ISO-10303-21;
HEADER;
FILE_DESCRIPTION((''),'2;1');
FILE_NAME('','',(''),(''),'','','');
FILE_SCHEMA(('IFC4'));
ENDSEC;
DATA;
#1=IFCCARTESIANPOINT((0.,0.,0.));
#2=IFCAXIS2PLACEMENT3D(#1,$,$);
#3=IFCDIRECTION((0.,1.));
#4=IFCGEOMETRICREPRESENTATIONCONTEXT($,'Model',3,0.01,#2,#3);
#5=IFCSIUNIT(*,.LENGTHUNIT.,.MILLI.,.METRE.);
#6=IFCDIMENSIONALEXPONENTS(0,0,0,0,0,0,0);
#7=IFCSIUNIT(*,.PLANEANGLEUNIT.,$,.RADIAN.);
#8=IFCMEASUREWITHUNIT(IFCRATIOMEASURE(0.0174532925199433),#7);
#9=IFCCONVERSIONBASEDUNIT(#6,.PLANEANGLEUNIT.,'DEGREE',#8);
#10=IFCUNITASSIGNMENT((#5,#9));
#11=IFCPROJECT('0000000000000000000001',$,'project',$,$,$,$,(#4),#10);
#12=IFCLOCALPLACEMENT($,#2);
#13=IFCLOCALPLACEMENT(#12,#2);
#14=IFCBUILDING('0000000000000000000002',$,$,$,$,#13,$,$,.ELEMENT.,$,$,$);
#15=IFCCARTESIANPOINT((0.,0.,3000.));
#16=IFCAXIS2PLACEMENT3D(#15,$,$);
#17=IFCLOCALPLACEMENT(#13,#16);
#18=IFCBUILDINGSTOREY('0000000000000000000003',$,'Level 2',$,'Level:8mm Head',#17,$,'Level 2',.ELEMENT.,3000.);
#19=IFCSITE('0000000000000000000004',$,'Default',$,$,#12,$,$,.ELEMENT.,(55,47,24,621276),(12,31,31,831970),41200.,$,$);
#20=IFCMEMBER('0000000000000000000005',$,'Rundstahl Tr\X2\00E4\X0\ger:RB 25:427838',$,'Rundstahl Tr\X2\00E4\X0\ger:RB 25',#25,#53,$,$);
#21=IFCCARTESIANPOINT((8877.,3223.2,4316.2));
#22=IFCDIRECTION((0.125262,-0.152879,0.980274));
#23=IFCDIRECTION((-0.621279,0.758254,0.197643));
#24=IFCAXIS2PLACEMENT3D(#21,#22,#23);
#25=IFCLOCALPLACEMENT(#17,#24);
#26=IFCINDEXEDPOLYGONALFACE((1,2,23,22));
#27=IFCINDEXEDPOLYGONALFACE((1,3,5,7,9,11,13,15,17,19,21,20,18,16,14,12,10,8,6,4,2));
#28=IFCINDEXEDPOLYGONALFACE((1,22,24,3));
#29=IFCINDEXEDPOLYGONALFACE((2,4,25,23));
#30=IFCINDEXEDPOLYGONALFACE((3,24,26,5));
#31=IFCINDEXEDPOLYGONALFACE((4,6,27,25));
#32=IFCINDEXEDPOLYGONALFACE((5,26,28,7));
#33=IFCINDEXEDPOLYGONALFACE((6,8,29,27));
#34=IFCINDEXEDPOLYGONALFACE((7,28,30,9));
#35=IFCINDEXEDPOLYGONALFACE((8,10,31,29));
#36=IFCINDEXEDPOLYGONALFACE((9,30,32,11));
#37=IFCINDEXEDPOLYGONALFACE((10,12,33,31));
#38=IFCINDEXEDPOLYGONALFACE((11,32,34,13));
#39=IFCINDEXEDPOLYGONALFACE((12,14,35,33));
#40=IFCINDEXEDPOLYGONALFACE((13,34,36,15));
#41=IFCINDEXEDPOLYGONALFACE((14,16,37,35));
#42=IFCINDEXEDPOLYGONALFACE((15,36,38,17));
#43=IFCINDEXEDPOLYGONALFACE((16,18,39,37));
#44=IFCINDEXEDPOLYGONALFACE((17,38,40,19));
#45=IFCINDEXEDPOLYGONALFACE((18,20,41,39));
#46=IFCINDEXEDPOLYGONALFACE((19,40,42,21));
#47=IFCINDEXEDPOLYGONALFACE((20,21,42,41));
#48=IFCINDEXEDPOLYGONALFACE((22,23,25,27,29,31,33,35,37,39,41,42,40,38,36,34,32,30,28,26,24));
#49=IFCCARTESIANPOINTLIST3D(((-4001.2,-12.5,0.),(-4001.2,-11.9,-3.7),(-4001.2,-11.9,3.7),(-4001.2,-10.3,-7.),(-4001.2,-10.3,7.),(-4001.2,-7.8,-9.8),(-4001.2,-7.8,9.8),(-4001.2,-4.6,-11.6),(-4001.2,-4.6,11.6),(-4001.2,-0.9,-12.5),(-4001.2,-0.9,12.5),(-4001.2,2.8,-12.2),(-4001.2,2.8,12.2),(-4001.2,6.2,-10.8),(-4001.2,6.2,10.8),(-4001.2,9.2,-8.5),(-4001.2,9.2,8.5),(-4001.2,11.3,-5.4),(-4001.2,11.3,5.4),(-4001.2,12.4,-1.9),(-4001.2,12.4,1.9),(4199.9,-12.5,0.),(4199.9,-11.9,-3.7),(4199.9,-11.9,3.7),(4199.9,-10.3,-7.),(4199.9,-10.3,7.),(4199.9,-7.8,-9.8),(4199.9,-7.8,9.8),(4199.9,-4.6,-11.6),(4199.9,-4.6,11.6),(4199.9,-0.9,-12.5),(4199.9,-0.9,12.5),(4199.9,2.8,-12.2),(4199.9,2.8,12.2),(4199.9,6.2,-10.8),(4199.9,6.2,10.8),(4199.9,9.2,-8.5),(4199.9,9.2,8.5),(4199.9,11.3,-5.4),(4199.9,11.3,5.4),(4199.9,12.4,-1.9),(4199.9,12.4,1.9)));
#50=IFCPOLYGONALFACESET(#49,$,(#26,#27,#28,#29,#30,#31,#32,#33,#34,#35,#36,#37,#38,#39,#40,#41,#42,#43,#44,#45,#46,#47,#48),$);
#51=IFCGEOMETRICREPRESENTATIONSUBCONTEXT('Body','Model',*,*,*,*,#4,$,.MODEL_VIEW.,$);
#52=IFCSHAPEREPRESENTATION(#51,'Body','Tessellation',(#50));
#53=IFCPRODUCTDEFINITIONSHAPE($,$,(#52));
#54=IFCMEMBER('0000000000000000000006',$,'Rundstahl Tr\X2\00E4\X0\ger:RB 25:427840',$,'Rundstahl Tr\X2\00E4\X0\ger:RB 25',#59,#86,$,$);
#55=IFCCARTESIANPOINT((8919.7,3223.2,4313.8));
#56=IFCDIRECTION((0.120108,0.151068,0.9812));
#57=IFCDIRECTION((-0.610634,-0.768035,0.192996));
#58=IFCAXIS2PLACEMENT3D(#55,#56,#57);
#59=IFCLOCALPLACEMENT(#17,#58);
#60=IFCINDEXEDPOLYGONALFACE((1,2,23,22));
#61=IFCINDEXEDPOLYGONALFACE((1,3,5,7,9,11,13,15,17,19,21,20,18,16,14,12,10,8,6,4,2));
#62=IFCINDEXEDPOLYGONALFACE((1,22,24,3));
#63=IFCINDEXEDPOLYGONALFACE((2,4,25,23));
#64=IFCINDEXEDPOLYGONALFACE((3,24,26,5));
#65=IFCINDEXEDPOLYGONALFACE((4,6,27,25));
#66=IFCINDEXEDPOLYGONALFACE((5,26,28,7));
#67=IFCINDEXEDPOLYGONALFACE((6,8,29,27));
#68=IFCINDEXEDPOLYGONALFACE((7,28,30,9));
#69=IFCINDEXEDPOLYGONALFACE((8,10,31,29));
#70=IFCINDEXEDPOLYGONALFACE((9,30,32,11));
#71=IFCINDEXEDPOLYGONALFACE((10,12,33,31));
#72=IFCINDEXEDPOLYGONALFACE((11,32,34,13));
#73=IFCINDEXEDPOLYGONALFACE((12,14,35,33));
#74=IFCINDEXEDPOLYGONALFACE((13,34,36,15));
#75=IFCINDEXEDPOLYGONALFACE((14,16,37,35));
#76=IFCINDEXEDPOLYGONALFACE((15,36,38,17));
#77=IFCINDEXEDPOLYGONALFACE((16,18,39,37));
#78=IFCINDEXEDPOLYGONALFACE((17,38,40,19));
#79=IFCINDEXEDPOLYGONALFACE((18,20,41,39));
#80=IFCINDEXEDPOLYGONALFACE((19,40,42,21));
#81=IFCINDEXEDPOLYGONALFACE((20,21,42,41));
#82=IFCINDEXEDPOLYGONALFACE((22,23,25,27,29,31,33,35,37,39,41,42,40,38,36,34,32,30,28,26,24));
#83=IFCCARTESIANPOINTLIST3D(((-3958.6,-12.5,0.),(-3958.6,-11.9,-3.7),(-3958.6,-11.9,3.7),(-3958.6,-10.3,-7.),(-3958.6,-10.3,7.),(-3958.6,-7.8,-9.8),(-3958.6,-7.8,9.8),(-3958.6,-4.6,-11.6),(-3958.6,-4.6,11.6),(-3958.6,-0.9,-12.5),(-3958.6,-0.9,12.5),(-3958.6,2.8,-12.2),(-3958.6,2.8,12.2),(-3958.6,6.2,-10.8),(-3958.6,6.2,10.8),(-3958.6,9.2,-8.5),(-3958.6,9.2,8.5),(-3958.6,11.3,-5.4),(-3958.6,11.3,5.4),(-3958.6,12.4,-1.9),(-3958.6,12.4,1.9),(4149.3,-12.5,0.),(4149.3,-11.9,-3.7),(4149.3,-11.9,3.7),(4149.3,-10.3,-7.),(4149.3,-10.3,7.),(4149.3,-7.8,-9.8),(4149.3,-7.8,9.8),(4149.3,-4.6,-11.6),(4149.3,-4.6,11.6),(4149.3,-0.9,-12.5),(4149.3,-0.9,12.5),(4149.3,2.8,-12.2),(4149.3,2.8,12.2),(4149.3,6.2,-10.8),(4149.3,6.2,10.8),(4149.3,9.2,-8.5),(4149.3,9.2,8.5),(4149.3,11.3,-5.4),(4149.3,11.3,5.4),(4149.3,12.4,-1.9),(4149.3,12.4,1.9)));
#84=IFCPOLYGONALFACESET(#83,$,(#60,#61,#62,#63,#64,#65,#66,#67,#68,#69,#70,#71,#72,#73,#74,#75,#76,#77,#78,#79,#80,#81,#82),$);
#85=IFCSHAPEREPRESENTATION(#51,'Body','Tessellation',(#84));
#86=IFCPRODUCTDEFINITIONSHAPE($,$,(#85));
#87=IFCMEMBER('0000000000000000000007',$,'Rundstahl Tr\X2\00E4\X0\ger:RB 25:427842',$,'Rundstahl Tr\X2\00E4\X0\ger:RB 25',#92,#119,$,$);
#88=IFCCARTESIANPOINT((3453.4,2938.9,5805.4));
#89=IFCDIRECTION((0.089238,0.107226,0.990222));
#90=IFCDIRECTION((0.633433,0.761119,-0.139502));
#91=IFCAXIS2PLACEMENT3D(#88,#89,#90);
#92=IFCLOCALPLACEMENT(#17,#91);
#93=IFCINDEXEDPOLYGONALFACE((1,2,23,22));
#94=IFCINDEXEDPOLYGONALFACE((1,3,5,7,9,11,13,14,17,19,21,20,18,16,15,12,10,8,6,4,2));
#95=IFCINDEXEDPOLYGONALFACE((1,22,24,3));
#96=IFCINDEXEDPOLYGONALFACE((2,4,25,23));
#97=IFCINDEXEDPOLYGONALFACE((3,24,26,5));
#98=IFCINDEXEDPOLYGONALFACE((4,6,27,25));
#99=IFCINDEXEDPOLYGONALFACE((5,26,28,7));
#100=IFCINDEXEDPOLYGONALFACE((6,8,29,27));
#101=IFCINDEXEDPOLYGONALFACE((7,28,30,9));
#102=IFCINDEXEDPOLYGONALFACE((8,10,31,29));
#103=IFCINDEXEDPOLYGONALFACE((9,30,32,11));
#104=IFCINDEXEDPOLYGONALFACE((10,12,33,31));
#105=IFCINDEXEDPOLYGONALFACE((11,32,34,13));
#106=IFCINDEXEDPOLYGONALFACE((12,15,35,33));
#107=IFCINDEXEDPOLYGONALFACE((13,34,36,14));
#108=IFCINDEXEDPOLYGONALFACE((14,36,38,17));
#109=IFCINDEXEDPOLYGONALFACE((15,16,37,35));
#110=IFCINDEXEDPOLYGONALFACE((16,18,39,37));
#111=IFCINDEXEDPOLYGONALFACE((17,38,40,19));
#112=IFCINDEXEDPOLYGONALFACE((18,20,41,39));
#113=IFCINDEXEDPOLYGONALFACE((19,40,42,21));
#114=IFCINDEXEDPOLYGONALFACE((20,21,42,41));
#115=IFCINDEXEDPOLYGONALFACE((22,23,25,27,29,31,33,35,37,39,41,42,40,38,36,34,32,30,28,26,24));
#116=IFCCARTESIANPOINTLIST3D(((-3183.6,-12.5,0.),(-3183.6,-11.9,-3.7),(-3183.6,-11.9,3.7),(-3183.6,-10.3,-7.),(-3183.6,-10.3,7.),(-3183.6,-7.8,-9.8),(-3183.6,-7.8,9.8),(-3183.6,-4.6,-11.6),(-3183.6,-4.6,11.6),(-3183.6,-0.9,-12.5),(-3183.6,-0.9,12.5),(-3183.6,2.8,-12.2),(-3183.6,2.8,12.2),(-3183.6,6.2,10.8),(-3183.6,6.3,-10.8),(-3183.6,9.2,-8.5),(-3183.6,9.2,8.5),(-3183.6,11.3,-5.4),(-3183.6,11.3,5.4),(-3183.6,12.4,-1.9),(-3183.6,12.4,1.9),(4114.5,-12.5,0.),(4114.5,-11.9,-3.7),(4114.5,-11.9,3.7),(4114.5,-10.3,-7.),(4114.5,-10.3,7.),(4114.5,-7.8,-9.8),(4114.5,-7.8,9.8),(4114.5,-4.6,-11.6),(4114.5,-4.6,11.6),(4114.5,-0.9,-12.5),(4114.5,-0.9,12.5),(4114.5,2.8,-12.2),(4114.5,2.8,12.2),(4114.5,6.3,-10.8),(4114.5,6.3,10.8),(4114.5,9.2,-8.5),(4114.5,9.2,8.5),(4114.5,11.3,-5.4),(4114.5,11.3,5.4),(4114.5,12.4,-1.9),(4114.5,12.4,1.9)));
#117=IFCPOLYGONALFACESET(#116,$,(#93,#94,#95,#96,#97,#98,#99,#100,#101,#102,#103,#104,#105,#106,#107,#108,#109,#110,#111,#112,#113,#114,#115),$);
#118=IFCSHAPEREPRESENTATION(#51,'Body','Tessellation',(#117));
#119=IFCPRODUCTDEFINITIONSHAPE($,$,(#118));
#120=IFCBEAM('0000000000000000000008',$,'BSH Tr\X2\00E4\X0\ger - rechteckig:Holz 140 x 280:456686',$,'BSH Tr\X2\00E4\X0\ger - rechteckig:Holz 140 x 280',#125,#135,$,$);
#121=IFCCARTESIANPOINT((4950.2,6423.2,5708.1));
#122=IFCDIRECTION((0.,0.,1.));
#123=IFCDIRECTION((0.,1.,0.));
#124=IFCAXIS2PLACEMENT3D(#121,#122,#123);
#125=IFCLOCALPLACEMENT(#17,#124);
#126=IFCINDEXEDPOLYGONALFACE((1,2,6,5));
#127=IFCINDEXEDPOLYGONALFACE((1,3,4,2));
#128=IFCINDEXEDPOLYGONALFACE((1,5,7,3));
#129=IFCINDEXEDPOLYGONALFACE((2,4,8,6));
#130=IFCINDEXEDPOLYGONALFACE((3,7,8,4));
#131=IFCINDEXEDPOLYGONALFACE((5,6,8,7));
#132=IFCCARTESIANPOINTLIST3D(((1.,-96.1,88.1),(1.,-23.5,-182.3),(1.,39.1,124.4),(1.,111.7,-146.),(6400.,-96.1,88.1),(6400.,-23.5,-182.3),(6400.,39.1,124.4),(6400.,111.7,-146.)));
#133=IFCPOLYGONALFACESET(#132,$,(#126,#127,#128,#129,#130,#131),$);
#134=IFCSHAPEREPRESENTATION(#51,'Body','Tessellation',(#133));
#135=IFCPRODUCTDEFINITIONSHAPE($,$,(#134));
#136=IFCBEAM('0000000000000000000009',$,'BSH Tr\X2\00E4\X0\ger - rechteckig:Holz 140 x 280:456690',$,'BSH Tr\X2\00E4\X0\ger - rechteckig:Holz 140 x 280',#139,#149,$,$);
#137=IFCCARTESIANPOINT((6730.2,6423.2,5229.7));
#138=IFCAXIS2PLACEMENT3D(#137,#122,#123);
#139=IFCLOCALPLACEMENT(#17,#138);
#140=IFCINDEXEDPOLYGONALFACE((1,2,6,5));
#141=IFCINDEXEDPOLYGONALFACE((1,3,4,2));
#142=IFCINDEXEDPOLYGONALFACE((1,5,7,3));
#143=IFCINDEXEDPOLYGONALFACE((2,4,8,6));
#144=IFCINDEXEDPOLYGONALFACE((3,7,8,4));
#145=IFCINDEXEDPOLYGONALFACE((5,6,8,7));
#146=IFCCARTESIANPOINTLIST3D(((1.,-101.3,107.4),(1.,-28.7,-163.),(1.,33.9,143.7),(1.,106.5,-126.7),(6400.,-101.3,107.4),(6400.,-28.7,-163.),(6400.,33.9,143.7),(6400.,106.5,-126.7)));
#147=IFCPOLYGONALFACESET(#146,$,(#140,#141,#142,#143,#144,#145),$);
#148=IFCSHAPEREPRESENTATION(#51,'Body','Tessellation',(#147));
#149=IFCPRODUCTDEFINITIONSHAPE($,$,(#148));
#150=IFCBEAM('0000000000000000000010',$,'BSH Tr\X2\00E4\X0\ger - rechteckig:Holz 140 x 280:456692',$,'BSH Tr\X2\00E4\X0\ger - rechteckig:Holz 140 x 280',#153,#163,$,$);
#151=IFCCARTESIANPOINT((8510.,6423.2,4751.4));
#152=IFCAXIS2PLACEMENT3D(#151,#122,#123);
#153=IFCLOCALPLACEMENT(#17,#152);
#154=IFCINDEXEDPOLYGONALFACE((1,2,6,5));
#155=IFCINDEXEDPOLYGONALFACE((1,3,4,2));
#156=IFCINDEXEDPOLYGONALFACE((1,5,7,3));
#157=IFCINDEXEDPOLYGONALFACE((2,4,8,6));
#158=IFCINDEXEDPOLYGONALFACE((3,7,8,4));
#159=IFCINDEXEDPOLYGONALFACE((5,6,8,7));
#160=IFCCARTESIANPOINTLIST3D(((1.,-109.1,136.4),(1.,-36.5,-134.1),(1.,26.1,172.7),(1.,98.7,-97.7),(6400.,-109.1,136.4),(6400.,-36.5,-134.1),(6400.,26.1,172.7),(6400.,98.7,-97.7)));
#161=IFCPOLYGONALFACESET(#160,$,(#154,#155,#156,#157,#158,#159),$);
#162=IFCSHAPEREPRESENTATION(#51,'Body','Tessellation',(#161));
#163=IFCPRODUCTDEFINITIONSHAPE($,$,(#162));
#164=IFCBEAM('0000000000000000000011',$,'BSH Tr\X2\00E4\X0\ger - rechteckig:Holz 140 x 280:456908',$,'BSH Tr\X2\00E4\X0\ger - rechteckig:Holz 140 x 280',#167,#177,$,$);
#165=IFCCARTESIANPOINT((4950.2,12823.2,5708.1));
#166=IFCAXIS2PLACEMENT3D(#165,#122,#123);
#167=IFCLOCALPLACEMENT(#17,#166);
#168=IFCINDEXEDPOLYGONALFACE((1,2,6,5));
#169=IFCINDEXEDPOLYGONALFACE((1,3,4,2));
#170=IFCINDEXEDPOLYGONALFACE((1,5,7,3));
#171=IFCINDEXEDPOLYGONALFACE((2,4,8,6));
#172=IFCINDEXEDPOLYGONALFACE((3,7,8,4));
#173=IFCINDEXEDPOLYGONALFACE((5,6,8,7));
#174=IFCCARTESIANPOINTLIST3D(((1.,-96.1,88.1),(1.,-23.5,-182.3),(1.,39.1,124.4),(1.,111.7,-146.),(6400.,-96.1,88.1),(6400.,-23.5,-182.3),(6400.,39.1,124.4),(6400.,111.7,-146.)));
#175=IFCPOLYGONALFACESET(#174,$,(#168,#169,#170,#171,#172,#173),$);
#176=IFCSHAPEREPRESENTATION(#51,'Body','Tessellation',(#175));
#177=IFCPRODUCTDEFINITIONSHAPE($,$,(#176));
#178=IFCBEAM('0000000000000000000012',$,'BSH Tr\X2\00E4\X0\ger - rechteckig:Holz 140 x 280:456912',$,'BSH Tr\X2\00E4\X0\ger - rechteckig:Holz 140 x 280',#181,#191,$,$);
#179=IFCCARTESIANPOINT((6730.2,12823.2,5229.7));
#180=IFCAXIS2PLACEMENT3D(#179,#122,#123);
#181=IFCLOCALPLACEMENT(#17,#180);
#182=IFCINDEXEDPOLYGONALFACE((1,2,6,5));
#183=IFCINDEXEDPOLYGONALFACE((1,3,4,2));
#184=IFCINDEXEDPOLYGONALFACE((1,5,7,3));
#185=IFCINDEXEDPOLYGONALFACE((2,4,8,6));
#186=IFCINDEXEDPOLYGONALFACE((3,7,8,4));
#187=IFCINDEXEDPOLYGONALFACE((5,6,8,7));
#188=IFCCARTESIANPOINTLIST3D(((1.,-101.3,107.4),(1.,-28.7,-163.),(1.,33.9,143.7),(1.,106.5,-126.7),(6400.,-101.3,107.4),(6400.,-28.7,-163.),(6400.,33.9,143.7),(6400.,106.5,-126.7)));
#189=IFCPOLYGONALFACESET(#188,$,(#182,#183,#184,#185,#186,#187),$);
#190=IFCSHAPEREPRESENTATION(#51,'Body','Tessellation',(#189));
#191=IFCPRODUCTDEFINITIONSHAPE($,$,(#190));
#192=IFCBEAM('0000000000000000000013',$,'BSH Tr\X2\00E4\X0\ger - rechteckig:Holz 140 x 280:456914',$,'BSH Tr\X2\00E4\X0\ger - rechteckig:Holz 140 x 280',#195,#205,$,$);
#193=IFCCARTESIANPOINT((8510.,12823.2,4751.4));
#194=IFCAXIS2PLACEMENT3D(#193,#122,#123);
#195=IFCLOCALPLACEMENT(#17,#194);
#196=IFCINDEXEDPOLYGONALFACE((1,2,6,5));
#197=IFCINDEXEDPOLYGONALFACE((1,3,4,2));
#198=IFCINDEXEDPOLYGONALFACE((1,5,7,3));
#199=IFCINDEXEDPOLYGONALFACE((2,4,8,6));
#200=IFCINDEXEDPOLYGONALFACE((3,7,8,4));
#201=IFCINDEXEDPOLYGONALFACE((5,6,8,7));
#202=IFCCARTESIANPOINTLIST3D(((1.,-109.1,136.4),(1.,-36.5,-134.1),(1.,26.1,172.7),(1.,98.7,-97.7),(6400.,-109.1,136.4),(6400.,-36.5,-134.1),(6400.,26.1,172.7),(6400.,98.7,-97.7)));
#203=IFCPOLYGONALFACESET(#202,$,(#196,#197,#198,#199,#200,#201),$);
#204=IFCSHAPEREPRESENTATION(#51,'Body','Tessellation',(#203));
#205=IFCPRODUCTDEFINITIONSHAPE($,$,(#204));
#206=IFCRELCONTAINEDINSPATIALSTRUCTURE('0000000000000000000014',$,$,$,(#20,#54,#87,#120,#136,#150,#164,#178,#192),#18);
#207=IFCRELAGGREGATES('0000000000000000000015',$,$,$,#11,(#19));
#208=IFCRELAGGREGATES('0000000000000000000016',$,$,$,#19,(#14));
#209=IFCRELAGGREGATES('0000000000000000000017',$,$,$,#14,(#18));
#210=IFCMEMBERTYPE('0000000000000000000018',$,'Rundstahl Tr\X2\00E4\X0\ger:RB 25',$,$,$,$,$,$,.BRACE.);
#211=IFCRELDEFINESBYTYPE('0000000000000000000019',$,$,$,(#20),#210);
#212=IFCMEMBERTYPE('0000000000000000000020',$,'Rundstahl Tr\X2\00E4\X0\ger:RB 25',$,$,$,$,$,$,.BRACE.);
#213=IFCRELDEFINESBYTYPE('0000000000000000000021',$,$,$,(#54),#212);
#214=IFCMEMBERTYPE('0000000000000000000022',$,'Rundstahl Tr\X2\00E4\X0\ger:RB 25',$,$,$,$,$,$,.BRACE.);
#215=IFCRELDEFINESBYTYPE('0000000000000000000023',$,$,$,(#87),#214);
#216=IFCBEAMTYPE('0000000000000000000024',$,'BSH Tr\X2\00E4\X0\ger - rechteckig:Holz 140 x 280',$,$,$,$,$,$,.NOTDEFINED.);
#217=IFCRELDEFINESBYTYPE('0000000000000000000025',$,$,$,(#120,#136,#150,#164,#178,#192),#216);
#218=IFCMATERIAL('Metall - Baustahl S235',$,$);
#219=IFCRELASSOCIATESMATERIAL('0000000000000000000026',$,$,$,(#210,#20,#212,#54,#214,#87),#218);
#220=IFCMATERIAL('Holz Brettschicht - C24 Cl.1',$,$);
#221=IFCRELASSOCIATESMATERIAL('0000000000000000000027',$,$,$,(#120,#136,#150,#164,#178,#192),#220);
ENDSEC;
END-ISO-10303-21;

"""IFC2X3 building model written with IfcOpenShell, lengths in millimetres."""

from ifc_helpers import new_model, entity, si_unit, converted_unit, direction, frame, frame_2d, origin, place, context, subcontext, project, spatial, rectangle, circle, extrude, source, transform, mapped, material, type_object, type_shapes, element, save


model = new_model("IFC2X3")

# Units and contexts
model_context = context("Model", 3, precision=0.01, world=origin(), true_north=direction((0.0, 1.0)))
body_context = subcontext(model_context, "Body", "Model", "MODEL_VIEW")
ifc_project = project(units=[si_unit("LENGTHUNIT", "METRE", prefix="MILLI"), converted_unit("PLANEANGLEUNIT", "DEGREE", entity("IfcRatioMeasure", 0.0174532925199433), si_unit("PLANEANGLEUNIT", "RADIAN"), dimensions=[0, 0, 0, 0, 0, 0, 0])], contexts=[model_context])

# Site, building, storey
site_placement = place(None, origin())
site = spatial("IfcSite", under=ifc_project, at=site_placement, Name="Default", CompositionType="ELEMENT", RefLatitude=(55, 47, 24, 621276), RefLongitude=(12, 31, 31, 831970), RefElevation=41200.0)
building_placement = place(site_placement, origin())
building = spatial("IfcBuilding", under=site, at=building_placement, CompositionType="ELEMENT")
storey_placement = place(building_placement, frame((0.0, 0.0, 3000.0)))
storey = spatial("IfcBuildingStorey", under=building, at=storey_placement, Name="Level 2", ObjectType="Level:8mm Head", LongName="Level 2", CompositionType="ELEMENT", Elevation=3000.0)

# Members
ifc_material_1 = material(Name="Metall - Baustahl S235")
member_type_1 = type_object("IfcMemberType", Name="Rundstahl Träger:RB 25", PredefinedType="BRACE", material=ifc_material_1)
shared_shape_1 = source(origin(), body_context, "Body", "SweptSolid", [
    extrude(circle(Radius=12.5, at=frame_2d((0.0, 0.0), x_axis=(1.0, 0.0))), frame((-4001.2, 0.0, 0.0), z_axis=(1.0, 0.0, 0.0), x_axis=(0.0, -1.0, 0.0)), (0.0, 0.0, 1.0), 8201.1),
])
type_shapes(member_type_1, [shared_shape_1])
member_1_placement = place(storey_placement, frame((8877.0, 3223.2, 4316.2), z_axis=(0.125262, -0.152879, 0.980274), x_axis=(-0.621279, 0.758254, 0.197643)))
element("IfcMember", 1, at=member_1_placement, inside=storey, type_object=member_type_1, material=ifc_material_1, Name="Rundstahl Träger:RB 25:427838", ObjectType="Rundstahl Träger:RB 25", context=body_context, shape_type="MappedRepresentation", body=[
    mapped(shared_shape_1, transform((0.0, 0.0, 0.0), scale=1.0)),
])
member_type_2 = type_object("IfcMemberType", Name="Rundstahl Träger:RB 25", PredefinedType="BRACE", material=ifc_material_1)
shared_shape_2 = source(origin(), body_context, "Body", "SweptSolid", [
    extrude(circle(Radius=12.5, at=frame_2d((0.0, 0.0), x_axis=(1.0, 0.0))), frame((-3958.6, 0.0, 0.0), z_axis=(1.0, 0.0, 0.0), x_axis=(0.0, -1.0, 0.0)), (0.0, 0.0, 1.0), 8107.9),
])
type_shapes(member_type_2, [shared_shape_2])
member_2_placement = place(storey_placement, frame((8919.7, 3223.2, 4313.8), z_axis=(0.120108, 0.151068, 0.9812), x_axis=(-0.610634, -0.768035, 0.192996)))
element("IfcMember", 2, at=member_2_placement, inside=storey, type_object=member_type_2, material=ifc_material_1, Name="Rundstahl Träger:RB 25:427840", ObjectType="Rundstahl Träger:RB 25", context=body_context, shape_type="MappedRepresentation", body=[
    mapped(shared_shape_2, transform((0.0, 0.0, 0.0), scale=1.0)),
])
member_type_3 = type_object("IfcMemberType", Name="Rundstahl Träger:RB 25", PredefinedType="BRACE", material=ifc_material_1)
shared_shape_3 = source(origin(), body_context, "Body", "SweptSolid", [
    extrude(circle(Radius=12.5, at=frame_2d((0.0, 0.0), x_axis=(1.0, 0.0))), frame((-3183.7, 0.0, 0.0), z_axis=(1.0, 0.0, 0.0), x_axis=(0.0, -1.0, 0.0)), (0.0, 0.0, 1.0), 7298.2),
])
type_shapes(member_type_3, [shared_shape_3])
member_3_placement = place(storey_placement, frame((3453.4, 2938.9, 5805.4), z_axis=(0.089238, 0.107226, 0.990222), x_axis=(0.633433, 0.761119, -0.139502)))
element("IfcMember", 3, at=member_3_placement, inside=storey, type_object=member_type_3, material=ifc_material_1, Name="Rundstahl Träger:RB 25:427842", ObjectType="Rundstahl Träger:RB 25", context=body_context, shape_type="MappedRepresentation", body=[
    mapped(shared_shape_3, transform((0.0, 0.0, 0.0), scale=1.0)),
])

# Beams
ifc_material_2 = material(Name="Holz Brettschicht - C24 Cl.1")
beam_type_1 = type_object("IfcBeamType", Name="BSH Träger - rechteckig:Holz 140 x 280", PredefinedType="NOTDEFINED")
beam_1_placement = place(storey_placement, frame((4950.2, 6423.2, 5708.1), z_axis=(0.0, 0.0, 1.0), x_axis=(0.0, 1.0, 0.0)))
element("IfcBeam", 4, at=beam_1_placement, inside=storey, type_object=beam_type_1, material=ifc_material_2, Name="BSH Träger - rechteckig:Holz 140 x 280:456686", ObjectType="BSH Träger - rechteckig:Holz 140 x 280", context=body_context, shape_type="SweptSolid", body=[
    extrude(rectangle(XDim=280.0, YDim=140.0, at=frame_2d((0.0, 0.0), x_axis=(1.0, 0.0))), frame((1.0, 7.8, -29.0), z_axis=(1.0, 0.0, 0.0), x_axis=(0.0, -0.259528, 0.965735)), (0.0, 0.0, 1.0), 6399.0),
])
beam_2_placement = place(storey_placement, frame((6730.2, 6423.2, 5229.7), z_axis=(0.0, 0.0, 1.0), x_axis=(0.0, 1.0, 0.0)))
element("IfcBeam", 5, at=beam_2_placement, inside=storey, type_object=beam_type_1, material=ifc_material_2, Name="BSH Träger - rechteckig:Holz 140 x 280:456690", ObjectType="BSH Träger - rechteckig:Holz 140 x 280", context=body_context, shape_type="SweptSolid", body=[
    extrude(rectangle(XDim=280.0, YDim=140.0, at=frame_2d((0.0, 0.0), x_axis=(1.0, 0.0))), frame((1.0, 2.6, -9.7), z_axis=(1.0, 0.0, 0.0), x_axis=(0.0, -0.259528, 0.965735)), (0.0, 0.0, 1.0), 6399.0),
])
beam_3_placement = place(storey_placement, frame((8510.0, 6423.2, 4751.4), z_axis=(0.0, 0.0, 1.0), x_axis=(0.0, 1.0, 0.0)))
element("IfcBeam", 6, at=beam_3_placement, inside=storey, type_object=beam_type_1, material=ifc_material_2, Name="BSH Träger - rechteckig:Holz 140 x 280:456692", ObjectType="BSH Träger - rechteckig:Holz 140 x 280", context=body_context, shape_type="SweptSolid", body=[
    extrude(rectangle(XDim=280.0, YDim=140.0, at=frame_2d((0.0, 0.0), x_axis=(1.0, 0.0))), frame((1.0, -5.2, 19.3), z_axis=(1.0, 0.0, 0.0), x_axis=(0.0, -0.259528, 0.965735)), (0.0, 0.0, 1.0), 6399.0),
])
beam_4_placement = place(storey_placement, frame((4950.2, 12823.2, 5708.1), z_axis=(0.0, 0.0, 1.0), x_axis=(0.0, 1.0, 0.0)))
element("IfcBeam", 7, at=beam_4_placement, inside=storey, type_object=beam_type_1, material=ifc_material_2, Name="BSH Träger - rechteckig:Holz 140 x 280:456908", ObjectType="BSH Träger - rechteckig:Holz 140 x 280", context=body_context, shape_type="SweptSolid", body=[
    extrude(rectangle(XDim=280.0, YDim=140.0, at=frame_2d((0.0, 0.0), x_axis=(1.0, 0.0))), frame((1.0, 7.8, -29.0), z_axis=(1.0, 0.0, 0.0), x_axis=(0.0, -0.259528, 0.965735)), (0.0, 0.0, 1.0), 6399.0),
])
beam_5_placement = place(storey_placement, frame((6730.2, 12823.2, 5229.7), z_axis=(0.0, 0.0, 1.0), x_axis=(0.0, 1.0, 0.0)))
element("IfcBeam", 8, at=beam_5_placement, inside=storey, type_object=beam_type_1, material=ifc_material_2, Name="BSH Träger - rechteckig:Holz 140 x 280:456912", ObjectType="BSH Träger - rechteckig:Holz 140 x 280", context=body_context, shape_type="SweptSolid", body=[
    extrude(rectangle(XDim=280.0, YDim=140.0, at=frame_2d((0.0, 0.0), x_axis=(1.0, 0.0))), frame((1.0, 2.6, -9.7), z_axis=(1.0, 0.0, 0.0), x_axis=(0.0, -0.259528, 0.965735)), (0.0, 0.0, 1.0), 6399.0),
])
beam_6_placement = place(storey_placement, frame((8510.0, 12823.2, 4751.4), z_axis=(0.0, 0.0, 1.0), x_axis=(0.0, 1.0, 0.0)))
element("IfcBeam", 9, at=beam_6_placement, inside=storey, type_object=beam_type_1, material=ifc_material_2, Name="BSH Träger - rechteckig:Holz 140 x 280:456914", ObjectType="BSH Träger - rechteckig:Holz 140 x 280", context=body_context, shape_type="SweptSolid", body=[
    extrude(rectangle(XDim=280.0, YDim=140.0, at=frame_2d((0.0, 0.0), x_axis=(1.0, 0.0))), frame((1.0, -5.2, 19.3), z_axis=(1.0, 0.0, 0.0), x_axis=(0.0, -0.259528, 0.965735)), (0.0, 0.0, 1.0), 6399.0),
])

save(model, "model.ifc")
